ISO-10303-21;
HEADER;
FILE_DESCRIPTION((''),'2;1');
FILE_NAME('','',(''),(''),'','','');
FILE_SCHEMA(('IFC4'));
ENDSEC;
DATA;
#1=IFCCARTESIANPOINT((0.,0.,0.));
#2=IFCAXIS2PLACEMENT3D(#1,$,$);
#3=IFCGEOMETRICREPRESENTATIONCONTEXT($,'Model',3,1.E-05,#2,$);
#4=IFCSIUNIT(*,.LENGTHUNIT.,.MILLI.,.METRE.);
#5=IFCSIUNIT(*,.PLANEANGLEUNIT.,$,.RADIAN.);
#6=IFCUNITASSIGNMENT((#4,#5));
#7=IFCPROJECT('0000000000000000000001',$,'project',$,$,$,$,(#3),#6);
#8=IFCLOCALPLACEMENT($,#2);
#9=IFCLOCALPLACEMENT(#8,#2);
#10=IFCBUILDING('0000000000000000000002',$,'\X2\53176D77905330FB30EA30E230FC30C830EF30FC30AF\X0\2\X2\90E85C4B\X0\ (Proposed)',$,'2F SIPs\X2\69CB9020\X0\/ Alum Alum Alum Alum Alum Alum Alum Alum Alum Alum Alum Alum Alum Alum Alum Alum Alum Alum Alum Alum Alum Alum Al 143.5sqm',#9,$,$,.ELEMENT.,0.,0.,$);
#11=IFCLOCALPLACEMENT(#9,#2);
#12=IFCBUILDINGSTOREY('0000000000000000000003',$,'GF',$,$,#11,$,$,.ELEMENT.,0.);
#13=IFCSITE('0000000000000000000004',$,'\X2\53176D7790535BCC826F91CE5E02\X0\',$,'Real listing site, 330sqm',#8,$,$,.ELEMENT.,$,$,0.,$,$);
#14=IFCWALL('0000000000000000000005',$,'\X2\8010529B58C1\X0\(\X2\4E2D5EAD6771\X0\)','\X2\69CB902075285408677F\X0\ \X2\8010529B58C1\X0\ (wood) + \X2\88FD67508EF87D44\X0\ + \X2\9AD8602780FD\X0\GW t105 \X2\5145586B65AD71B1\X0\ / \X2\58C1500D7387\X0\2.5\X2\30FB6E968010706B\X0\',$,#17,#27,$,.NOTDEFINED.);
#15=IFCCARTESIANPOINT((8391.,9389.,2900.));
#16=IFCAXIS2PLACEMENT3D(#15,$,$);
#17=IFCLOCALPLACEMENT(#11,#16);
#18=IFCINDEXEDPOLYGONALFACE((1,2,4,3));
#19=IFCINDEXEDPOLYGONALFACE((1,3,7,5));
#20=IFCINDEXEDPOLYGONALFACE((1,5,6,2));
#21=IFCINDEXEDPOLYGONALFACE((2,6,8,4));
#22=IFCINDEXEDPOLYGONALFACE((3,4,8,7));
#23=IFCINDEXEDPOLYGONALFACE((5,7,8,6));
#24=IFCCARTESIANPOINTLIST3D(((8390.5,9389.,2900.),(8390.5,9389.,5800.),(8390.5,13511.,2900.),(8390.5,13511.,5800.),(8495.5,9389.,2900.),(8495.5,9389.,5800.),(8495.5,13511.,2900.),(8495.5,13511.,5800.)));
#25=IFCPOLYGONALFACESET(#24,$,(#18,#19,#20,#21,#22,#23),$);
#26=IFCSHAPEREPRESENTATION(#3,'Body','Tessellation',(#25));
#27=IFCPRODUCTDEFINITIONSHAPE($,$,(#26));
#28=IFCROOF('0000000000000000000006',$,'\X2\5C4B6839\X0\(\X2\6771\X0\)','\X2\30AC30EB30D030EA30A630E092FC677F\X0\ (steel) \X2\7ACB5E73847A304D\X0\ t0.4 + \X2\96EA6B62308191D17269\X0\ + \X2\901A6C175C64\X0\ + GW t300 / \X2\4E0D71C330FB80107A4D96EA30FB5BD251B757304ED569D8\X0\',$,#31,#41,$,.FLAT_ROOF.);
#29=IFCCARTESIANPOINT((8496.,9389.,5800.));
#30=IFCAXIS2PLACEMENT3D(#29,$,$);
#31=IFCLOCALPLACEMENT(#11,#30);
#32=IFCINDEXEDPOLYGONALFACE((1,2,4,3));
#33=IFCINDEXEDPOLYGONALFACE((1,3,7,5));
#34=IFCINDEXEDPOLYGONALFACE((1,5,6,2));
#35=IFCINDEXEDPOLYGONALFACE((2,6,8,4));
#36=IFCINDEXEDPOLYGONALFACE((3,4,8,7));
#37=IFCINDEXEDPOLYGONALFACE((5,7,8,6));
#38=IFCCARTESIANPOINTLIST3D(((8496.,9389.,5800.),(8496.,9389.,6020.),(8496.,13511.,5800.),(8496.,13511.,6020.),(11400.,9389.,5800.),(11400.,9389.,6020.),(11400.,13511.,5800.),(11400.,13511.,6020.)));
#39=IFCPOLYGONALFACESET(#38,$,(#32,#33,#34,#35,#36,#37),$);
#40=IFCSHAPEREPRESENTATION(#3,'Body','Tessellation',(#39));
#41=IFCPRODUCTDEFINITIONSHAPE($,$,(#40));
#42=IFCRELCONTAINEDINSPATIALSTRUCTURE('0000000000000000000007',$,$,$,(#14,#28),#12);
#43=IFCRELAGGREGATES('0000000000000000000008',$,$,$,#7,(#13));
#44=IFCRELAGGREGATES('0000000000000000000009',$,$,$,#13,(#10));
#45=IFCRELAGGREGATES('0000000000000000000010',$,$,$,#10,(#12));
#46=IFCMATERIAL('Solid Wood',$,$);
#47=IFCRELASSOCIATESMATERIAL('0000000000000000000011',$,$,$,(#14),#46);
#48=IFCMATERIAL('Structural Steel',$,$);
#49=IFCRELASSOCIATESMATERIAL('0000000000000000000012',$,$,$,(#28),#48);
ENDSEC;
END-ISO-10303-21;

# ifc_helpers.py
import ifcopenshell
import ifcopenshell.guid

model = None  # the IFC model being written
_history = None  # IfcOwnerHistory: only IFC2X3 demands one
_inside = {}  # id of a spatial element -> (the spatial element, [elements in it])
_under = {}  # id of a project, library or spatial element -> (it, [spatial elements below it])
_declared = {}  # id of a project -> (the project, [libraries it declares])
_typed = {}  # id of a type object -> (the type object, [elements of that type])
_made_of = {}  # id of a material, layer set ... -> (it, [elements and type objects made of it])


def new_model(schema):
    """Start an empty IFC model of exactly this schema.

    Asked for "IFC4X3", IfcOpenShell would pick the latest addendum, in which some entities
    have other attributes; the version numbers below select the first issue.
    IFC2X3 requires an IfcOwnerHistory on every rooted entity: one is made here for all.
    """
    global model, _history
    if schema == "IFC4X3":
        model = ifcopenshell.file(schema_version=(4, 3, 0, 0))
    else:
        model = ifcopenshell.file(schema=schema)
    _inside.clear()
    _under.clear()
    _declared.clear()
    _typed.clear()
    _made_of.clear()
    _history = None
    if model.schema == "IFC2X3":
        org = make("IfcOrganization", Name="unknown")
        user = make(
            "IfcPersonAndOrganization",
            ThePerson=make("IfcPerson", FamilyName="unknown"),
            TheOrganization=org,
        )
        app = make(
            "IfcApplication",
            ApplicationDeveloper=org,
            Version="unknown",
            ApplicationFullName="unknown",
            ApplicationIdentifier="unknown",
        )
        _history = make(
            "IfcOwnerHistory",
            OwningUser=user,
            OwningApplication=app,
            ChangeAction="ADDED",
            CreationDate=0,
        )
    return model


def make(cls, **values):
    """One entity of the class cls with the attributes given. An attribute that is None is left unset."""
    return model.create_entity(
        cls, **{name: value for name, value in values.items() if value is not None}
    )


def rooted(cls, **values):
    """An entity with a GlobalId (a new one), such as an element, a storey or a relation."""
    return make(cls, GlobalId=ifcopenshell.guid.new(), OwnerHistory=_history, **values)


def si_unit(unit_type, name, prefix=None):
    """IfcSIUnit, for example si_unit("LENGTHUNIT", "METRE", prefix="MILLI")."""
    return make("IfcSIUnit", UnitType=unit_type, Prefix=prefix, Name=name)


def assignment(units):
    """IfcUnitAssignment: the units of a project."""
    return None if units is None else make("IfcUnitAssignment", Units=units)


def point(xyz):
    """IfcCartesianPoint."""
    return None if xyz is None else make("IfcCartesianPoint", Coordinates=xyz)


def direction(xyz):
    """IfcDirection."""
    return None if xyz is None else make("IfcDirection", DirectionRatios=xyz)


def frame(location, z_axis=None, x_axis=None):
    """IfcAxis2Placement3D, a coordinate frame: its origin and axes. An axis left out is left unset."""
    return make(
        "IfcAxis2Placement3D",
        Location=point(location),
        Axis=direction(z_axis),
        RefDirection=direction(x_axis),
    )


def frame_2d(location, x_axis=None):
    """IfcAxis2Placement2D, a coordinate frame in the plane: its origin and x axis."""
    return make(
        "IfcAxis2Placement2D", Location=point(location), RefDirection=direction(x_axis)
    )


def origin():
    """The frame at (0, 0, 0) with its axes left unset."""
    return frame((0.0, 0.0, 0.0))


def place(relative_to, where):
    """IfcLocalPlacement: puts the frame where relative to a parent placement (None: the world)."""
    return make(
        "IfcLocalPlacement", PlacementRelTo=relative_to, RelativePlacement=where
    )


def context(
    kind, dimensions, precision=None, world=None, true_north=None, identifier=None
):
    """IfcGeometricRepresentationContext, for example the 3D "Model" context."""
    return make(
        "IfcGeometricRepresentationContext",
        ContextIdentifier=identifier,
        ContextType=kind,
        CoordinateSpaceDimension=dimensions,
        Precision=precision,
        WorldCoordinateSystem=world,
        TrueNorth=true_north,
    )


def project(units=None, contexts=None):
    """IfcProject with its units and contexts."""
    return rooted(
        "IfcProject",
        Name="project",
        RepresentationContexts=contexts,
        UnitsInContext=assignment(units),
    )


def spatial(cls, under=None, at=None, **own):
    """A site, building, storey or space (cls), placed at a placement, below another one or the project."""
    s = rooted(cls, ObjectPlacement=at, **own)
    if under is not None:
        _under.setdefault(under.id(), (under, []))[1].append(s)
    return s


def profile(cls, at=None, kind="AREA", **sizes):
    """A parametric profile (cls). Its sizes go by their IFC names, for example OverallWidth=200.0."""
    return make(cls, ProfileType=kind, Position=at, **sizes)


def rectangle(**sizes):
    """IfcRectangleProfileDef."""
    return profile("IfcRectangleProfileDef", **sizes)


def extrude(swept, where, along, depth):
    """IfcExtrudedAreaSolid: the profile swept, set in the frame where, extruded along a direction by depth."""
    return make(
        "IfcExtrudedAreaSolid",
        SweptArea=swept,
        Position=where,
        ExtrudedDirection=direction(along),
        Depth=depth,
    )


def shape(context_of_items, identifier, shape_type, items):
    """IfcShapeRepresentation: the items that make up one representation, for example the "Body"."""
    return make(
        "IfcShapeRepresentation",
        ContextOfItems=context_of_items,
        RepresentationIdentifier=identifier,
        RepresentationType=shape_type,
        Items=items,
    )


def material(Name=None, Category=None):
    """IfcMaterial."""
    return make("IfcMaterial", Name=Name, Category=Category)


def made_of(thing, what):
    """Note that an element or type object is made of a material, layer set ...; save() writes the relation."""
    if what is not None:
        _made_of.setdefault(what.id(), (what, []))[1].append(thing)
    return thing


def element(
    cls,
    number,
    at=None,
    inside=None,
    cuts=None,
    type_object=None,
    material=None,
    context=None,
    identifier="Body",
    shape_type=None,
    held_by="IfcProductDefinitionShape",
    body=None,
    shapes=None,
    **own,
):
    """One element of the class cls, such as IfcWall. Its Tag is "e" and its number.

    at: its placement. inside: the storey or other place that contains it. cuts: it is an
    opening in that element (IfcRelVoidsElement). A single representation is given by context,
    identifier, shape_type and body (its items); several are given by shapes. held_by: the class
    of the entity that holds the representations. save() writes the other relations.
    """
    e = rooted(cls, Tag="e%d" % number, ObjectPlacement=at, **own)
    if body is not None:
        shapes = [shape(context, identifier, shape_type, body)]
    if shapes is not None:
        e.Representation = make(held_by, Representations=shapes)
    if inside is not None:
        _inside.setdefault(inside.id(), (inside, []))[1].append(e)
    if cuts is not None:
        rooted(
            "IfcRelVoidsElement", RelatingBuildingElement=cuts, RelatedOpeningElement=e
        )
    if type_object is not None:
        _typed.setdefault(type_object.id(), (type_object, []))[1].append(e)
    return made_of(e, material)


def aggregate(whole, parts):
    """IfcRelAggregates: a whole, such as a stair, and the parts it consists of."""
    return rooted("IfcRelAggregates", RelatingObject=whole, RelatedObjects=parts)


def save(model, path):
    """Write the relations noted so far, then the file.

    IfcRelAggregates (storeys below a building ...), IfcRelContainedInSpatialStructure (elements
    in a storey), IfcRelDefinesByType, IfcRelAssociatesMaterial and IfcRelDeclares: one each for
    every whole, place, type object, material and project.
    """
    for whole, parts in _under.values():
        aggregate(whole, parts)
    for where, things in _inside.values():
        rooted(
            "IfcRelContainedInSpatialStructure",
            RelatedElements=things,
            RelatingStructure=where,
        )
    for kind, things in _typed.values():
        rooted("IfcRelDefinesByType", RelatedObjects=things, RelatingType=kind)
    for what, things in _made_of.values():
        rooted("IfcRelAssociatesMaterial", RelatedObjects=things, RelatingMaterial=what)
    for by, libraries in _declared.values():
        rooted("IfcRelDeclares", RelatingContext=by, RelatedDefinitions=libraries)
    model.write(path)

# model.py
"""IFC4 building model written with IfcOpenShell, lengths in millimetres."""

from ifc_helpers import new_model, si_unit, frame, frame_2d, origin, place, context, project, spatial, rectangle, extrude, material, element, save


model = new_model("IFC4")

# Units and contexts
model_context = context("Model", 3, precision=1e-05, world=origin())
ifc_project = project(units=[si_unit("LENGTHUNIT", "METRE", prefix="MILLI"), si_unit("PLANEANGLEUNIT", "RADIAN")], contexts=[model_context])

# Site, building, storey
site_placement = place(None, origin())
site = spatial("IfcSite", under=ifc_project, at=site_placement, Name="北海道富良野市", ObjectType="Real listing site, 330sqm", CompositionType="ELEMENT", RefElevation=0.0)
building_placement = place(site_placement, origin())
building = spatial("IfcBuilding", under=site, at=building_placement, Name="北海道・リモートワーク2部屋 (Proposed)", ObjectType="2F SIPs構造/ Alum Alum Alum Alum Alum Alum Alum Alum Alum Alum Alum Alum Alum Alum Alum Alum Alum Alum Alum Alum Alum Alum Al 143.5sqm", CompositionType="ELEMENT", ElevationOfRefHeight=0.0, ElevationOfTerrain=0.0)
storey_placement = place(building_placement, origin())
storey = spatial("IfcBuildingStorey", under=building, at=storey_placement, Name="GF", CompositionType="ELEMENT", Elevation=0.0)

# Shared definitions
ifc_material_1 = material(Name="Solid Wood")

# Wall
wall_1_placement = place(storey_placement, frame((8391.0, 9389.0, 2900.0)))
element("IfcWall", 1, at=wall_1_placement, inside=storey, material=ifc_material_1, Name="耐力壁(中庭東)", Description="構造用合板 耐力壁 (wood) + 製材軸組 + 高性能GW t105 充填断熱 / 壁倍率2.5・準耐火", PredefinedType="NOTDEFINED", context=model_context, shape_type="SweptSolid", body=[
    extrude(rectangle(XDim=105.0, YDim=4122.0, at=frame_2d((52.0, 2061.0))), frame((8391.0, 9389.0, 2900.0)), (0.0, 0.0, 1.0), 2900.0),
])

# Roof
ifc_material_2 = material(Name="Structural Steel")
for number, where, name in (
    (2, (8496.0, 9389.0, 5800.0), "屋根(東)"),
):
    element("IfcRoof", number, at=place(storey_placement, frame(where)), inside=storey, material=ifc_material_2, Name=name, Description="ガルバリウム鋼板 (steel) 立平葺き t0.4 + 雪止め金物 + 通気層 + GW t300 / 不燃・耐積雪・寒冷地仕様", PredefinedType="FLAT_ROOF", context=model_context, shape_type="SweptSolid", body=[
        extrude(rectangle(XDim=2904.0, YDim=4122.0, at=frame_2d((1452.0, 2061.0))), frame((8496.0, 9389.0, 5800.0)), (0.0, 0.0, 1.0), 220.0),
    ])

save(model, "model.ifc")
